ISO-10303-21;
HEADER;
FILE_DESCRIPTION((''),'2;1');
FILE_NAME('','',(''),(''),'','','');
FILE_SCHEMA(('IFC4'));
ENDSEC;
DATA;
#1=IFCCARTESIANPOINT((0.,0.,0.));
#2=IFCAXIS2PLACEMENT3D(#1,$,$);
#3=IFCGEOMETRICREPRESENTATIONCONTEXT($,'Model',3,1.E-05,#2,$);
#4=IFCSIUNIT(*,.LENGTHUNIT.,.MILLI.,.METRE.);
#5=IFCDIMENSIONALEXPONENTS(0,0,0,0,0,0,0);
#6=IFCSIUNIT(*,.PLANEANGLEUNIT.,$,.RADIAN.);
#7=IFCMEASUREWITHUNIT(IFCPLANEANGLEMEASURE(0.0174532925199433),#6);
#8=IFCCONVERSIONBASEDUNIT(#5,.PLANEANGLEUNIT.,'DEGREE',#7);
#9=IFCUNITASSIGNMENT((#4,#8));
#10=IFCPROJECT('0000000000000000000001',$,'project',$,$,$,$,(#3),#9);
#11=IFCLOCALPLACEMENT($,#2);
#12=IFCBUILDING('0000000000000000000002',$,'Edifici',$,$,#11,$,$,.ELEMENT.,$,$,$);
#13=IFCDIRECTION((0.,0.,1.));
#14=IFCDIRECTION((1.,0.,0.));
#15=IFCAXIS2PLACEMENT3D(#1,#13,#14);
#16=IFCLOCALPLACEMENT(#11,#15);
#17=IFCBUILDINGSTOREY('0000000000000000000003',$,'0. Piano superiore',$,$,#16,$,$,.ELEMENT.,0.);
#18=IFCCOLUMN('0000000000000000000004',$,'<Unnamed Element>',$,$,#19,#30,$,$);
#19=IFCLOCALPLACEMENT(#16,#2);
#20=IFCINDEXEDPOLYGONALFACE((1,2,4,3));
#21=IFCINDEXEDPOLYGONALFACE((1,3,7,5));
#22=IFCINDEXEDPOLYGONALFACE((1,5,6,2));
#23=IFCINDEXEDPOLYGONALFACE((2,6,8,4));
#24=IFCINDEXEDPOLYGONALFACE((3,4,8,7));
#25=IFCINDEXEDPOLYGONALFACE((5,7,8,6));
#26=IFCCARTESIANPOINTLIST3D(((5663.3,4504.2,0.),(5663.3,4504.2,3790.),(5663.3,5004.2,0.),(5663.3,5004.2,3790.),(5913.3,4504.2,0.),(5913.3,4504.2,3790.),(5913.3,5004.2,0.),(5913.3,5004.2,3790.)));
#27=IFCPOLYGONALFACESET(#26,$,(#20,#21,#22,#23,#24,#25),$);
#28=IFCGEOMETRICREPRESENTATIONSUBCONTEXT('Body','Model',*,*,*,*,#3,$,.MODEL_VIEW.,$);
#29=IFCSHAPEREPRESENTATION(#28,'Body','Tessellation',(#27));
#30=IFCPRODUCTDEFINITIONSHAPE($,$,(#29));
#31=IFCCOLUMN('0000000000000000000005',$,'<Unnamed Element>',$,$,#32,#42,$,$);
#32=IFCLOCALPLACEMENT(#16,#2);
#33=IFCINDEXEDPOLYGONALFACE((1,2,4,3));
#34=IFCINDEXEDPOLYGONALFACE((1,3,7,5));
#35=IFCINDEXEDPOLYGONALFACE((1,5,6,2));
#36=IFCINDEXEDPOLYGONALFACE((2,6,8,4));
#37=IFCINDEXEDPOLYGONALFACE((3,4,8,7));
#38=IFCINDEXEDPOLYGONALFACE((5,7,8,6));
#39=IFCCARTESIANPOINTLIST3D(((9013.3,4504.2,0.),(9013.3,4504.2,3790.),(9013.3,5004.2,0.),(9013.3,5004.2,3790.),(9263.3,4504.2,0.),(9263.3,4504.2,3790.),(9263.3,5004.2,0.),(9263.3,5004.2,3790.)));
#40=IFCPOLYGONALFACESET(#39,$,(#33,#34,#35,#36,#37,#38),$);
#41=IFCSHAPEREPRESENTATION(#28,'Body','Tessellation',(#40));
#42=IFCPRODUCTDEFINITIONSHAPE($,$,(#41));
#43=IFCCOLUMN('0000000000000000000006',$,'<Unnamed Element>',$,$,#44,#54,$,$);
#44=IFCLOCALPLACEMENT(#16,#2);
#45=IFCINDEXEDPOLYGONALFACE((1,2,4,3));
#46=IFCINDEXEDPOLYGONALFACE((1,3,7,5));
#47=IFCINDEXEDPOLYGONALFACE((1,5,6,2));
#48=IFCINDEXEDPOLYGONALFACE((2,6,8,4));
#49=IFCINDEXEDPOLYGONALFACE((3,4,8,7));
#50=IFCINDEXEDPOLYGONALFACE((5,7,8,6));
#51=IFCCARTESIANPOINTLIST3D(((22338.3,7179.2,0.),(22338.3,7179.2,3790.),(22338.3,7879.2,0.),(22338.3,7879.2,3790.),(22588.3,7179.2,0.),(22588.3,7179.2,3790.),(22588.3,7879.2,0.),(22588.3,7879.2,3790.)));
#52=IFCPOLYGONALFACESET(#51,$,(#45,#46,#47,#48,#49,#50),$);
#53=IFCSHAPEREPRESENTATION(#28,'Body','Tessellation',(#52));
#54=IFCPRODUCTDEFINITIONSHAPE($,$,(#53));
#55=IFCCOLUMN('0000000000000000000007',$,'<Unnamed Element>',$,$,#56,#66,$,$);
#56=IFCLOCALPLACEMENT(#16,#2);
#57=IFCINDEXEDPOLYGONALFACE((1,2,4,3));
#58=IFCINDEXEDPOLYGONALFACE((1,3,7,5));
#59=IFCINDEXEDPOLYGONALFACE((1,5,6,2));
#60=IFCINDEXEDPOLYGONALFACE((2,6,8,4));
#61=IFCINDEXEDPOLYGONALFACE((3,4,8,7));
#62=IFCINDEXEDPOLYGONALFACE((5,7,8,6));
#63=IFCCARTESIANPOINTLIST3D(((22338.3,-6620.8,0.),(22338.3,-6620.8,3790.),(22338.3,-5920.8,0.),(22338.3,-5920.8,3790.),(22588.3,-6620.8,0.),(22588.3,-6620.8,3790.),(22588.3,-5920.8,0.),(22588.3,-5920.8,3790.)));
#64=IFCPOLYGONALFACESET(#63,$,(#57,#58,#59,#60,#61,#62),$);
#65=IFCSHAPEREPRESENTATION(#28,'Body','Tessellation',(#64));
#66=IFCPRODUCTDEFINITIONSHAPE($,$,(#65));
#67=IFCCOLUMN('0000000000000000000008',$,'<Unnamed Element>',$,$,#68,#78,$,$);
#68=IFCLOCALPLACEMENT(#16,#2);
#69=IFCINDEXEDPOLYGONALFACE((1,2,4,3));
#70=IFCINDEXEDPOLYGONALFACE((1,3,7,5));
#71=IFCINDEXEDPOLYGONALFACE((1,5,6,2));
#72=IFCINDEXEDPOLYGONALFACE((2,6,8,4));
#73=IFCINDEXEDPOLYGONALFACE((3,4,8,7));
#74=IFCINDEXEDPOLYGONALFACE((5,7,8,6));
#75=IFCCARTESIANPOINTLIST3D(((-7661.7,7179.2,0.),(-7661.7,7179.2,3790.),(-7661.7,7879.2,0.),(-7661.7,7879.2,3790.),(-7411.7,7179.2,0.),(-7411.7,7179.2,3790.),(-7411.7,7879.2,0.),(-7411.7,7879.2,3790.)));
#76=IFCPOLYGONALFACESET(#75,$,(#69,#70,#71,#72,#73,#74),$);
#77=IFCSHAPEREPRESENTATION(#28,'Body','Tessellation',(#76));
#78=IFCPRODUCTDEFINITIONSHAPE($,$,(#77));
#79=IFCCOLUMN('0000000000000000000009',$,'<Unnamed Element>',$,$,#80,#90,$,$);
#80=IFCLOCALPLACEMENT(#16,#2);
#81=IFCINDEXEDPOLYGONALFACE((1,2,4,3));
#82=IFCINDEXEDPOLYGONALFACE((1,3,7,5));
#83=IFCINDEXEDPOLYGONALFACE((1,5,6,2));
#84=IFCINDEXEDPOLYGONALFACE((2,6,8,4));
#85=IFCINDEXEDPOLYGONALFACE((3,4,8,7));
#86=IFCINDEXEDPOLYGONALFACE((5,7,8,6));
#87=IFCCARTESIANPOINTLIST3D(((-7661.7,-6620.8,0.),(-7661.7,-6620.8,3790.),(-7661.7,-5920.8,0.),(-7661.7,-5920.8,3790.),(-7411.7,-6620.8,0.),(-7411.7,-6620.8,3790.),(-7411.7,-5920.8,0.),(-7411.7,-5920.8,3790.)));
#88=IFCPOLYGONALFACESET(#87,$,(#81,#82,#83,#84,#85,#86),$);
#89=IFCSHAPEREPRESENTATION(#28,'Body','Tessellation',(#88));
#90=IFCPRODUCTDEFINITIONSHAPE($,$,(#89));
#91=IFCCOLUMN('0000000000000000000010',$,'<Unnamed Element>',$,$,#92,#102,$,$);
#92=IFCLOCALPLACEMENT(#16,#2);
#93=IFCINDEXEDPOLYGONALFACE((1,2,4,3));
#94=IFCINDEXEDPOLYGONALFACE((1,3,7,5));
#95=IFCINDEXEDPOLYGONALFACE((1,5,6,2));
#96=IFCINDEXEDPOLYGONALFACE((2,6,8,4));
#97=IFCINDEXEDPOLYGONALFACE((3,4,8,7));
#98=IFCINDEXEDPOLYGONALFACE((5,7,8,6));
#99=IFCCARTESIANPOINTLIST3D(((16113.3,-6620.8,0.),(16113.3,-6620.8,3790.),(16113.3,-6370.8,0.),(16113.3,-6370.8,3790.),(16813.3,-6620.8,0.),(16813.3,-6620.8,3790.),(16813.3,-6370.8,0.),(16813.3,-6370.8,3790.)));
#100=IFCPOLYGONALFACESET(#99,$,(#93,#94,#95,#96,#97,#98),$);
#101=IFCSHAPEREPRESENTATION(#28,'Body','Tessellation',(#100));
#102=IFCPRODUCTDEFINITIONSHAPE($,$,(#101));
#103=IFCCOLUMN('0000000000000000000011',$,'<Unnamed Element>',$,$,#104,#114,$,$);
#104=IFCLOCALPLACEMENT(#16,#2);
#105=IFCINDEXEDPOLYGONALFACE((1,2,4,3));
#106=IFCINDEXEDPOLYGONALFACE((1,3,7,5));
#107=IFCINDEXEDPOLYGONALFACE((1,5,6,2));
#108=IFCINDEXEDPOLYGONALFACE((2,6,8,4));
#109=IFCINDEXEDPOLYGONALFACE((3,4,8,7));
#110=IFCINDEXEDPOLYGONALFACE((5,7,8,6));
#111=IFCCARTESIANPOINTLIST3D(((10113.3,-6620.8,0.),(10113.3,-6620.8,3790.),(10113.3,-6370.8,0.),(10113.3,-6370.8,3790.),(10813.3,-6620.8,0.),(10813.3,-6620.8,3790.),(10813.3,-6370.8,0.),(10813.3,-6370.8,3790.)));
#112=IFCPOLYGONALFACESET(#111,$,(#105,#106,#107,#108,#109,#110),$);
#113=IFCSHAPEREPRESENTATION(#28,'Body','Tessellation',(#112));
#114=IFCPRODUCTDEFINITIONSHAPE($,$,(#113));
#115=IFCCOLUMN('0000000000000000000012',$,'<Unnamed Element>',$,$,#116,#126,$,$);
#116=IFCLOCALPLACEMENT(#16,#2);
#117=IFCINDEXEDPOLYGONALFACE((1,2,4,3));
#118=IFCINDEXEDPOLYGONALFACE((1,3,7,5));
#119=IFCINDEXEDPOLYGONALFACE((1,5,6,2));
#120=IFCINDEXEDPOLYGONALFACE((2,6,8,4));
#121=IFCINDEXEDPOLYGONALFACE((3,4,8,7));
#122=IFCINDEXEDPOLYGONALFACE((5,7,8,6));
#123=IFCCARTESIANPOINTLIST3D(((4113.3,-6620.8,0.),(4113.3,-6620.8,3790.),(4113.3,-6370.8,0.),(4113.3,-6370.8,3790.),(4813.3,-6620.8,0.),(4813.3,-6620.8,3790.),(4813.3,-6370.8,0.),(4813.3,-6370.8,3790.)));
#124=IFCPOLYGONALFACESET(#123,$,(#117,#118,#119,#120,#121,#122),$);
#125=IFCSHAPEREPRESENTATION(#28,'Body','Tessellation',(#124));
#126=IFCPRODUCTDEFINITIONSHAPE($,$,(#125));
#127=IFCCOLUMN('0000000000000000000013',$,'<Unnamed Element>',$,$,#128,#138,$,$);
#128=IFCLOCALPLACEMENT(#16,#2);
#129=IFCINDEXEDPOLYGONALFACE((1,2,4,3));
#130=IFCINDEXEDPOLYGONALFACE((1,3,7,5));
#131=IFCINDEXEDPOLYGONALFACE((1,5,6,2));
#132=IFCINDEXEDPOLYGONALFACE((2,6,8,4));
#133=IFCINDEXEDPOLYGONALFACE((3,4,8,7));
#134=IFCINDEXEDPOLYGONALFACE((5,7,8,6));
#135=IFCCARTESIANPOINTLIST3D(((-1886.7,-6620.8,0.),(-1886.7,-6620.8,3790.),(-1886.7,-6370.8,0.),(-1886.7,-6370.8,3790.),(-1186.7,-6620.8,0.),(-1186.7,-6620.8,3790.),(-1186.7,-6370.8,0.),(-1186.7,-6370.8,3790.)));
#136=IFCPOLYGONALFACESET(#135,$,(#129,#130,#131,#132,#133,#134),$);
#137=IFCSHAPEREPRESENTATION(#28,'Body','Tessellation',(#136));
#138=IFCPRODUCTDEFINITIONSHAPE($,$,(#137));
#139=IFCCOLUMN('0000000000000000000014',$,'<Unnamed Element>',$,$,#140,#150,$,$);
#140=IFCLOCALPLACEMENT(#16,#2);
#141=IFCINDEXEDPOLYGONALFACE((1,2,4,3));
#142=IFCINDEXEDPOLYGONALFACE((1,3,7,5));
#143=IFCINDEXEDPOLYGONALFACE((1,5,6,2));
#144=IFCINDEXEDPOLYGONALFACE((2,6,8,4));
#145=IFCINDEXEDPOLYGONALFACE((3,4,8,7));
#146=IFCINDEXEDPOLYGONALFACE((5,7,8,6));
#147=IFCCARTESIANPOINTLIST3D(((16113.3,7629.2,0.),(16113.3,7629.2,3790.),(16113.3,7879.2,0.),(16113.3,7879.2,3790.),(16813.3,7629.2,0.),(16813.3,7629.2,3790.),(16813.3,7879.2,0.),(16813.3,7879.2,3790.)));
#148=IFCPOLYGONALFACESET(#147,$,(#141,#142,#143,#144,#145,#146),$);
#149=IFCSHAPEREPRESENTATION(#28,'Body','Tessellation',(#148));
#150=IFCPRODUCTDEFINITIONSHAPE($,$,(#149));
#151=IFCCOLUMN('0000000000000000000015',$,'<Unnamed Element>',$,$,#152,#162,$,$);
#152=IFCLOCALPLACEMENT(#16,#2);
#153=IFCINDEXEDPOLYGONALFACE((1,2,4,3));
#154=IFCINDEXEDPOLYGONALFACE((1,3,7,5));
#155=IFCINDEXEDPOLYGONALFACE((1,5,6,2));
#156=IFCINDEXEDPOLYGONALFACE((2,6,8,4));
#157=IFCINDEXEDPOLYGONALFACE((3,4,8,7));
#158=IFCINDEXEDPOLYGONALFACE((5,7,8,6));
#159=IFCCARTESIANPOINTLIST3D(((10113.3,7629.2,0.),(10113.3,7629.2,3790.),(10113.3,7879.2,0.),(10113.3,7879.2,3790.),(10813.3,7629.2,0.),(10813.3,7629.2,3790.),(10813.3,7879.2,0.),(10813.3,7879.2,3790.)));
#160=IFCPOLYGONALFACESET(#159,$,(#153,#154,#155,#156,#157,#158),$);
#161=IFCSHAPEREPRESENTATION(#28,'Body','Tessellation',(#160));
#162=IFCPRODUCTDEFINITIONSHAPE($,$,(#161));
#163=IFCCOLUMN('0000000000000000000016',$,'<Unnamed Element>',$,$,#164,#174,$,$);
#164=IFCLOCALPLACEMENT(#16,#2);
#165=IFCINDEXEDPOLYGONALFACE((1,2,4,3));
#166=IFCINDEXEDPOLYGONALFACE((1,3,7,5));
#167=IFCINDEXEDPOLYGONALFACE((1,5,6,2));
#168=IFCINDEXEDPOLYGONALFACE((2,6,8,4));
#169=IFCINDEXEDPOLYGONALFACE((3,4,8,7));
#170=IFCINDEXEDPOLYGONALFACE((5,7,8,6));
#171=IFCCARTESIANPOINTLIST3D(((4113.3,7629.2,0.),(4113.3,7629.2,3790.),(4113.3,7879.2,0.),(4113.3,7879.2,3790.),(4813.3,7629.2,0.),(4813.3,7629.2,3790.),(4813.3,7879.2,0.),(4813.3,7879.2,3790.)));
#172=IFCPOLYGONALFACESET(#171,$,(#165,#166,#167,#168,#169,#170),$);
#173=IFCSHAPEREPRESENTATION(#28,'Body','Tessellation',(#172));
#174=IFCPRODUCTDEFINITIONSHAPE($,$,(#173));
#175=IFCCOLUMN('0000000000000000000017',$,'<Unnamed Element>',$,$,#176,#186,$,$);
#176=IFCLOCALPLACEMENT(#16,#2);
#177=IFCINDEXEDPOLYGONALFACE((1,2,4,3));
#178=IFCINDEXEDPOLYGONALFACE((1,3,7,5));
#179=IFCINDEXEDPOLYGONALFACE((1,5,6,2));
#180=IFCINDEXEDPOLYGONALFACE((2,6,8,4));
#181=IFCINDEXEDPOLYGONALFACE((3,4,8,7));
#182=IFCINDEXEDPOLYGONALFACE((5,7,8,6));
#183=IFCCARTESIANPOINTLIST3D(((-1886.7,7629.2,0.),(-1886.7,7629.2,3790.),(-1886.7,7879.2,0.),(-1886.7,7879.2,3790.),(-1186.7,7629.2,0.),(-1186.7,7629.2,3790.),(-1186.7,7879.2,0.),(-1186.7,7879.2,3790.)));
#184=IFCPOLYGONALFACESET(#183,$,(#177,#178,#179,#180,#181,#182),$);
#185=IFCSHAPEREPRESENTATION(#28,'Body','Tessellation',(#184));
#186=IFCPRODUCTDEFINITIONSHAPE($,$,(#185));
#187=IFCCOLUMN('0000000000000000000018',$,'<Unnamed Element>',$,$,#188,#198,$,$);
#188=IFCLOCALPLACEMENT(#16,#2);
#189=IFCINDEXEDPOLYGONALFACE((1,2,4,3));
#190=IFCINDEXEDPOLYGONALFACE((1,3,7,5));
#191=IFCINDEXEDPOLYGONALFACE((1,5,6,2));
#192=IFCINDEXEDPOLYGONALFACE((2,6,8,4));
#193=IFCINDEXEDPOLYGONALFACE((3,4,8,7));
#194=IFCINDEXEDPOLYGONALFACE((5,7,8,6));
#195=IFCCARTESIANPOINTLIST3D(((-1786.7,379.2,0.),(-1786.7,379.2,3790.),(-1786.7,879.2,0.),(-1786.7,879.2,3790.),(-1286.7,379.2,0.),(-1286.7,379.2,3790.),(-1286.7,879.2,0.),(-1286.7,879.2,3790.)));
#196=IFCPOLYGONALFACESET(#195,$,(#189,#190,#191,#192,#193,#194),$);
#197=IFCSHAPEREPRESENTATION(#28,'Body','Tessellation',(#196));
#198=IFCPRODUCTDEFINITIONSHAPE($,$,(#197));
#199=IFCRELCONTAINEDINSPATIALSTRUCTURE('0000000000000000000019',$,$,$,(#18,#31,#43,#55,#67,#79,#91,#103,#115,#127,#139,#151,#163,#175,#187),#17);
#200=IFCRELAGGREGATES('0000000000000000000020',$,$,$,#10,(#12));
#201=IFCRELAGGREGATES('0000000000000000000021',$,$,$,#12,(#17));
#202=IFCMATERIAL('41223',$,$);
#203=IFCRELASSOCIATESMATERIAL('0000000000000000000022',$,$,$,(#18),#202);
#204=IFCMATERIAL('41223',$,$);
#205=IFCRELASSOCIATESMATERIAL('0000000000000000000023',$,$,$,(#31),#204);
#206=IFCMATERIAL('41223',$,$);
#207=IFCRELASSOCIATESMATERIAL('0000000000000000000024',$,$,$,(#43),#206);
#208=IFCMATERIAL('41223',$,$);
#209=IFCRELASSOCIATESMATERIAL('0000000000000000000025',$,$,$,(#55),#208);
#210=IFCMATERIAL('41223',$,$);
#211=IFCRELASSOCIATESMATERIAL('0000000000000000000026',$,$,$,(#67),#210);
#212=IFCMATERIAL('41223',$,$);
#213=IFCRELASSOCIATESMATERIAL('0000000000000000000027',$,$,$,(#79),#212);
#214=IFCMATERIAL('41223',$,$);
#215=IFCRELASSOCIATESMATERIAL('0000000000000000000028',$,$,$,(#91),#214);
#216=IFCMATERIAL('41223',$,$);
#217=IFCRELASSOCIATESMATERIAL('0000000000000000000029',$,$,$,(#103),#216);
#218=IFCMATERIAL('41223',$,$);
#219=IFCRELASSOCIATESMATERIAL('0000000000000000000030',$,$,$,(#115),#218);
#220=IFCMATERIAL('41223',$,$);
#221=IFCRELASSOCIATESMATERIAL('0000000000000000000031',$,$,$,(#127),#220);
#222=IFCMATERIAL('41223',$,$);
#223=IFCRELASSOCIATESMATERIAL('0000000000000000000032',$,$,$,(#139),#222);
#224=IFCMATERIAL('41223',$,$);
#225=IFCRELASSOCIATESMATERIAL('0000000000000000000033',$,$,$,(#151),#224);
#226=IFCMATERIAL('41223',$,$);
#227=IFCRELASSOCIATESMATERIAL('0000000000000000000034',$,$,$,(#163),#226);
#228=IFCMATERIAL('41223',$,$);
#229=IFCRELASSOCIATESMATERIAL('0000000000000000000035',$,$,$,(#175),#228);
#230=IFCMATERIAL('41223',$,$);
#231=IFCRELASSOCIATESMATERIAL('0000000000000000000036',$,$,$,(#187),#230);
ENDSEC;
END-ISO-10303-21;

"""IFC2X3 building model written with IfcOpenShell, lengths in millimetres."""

from ifc_helpers import new_model, entity, si_unit, converted_unit, frame, frame_2d, origin, origin_with_axes, place, context, subcontext, project, spatial, rectangle, extrude, material, element, save


model = new_model("IFC2X3")

# Units and contexts
model_context = context("Model", 3, precision=1e-05, world=origin())
body_context = subcontext(model_context, "Body", "Model", "MODEL_VIEW")
ifc_project = project(units=[si_unit("LENGTHUNIT", "METRE", prefix="MILLI"), converted_unit("PLANEANGLEUNIT", "DEGREE", entity("IfcPlaneAngleMeasure", 0.0174532925199433), si_unit("PLANEANGLEUNIT", "RADIAN"), dimensions=[0, 0, 0, 0, 0, 0, 0])], contexts=[model_context])

# Building, storey
building_placement = place(None, origin())
building = spatial("IfcBuilding", under=ifc_project, at=building_placement, Name="Edifici", CompositionType="ELEMENT")
storey_placement = place(building_placement, origin_with_axes())
storey = spatial("IfcBuildingStorey", under=building, at=storey_placement, Name="0. Piano superiore", CompositionType="ELEMENT", Elevation=0.0)

# Columns
ifc_material_1 = material(Name="41223")
column_1_placement = place(storey_placement, frame((5913.3, 5004.2, 0.0), z_axis=(0.0, 0.0, 1.0), x_axis=(1.0, 0.0, 0.0)))
element("IfcColumn", 1, at=column_1_placement, inside=storey, material=ifc_material_1, Name="<Unnamed Element>", context=body_context, shape_type="SweptSolid", body=[
    extrude(rectangle(XDim=250.0, YDim=500.0, at=frame_2d((-125.0, -250.0), x_axis=(-1.0, 0.0))), origin_with_axes(), (0.0, 0.0, 1.0), 3790.0),
])
ifc_material_2 = material(Name="41223")
column_2_placement = place(storey_placement, frame((9263.3, 5004.2, 0.0), z_axis=(0.0, 0.0, 1.0), x_axis=(1.0, 0.0, 0.0)))
element("IfcColumn", 2, at=column_2_placement, inside=storey, material=ifc_material_2, Name="<Unnamed Element>", context=body_context, shape_type="SweptSolid", body=[
    extrude(rectangle(XDim=250.0, YDim=500.0, at=frame_2d((-125.0, -250.0), x_axis=(-1.0, 0.0))), origin_with_axes(), (0.0, 0.0, 1.0), 3790.0),
])
ifc_material_3 = material(Name="41223")
column_3_placement = place(storey_placement, frame((22588.3, 7879.2, 0.0), z_axis=(0.0, 0.0, 1.0), x_axis=(1.0, 0.0, 0.0)))
element("IfcColumn", 3, at=column_3_placement, inside=storey, material=ifc_material_3, Name="<Unnamed Element>", context=body_context, shape_type="SweptSolid", body=[
    extrude(rectangle(XDim=250.0, YDim=700.0, at=frame_2d((-125.0, -350.0), x_axis=(-1.0, 0.0))), origin_with_axes(), (0.0, 0.0, 1.0), 3790.0),
])
ifc_material_4 = material(Name="41223")
column_4_placement = place(storey_placement, frame((22588.3, -5920.8, 0.0), z_axis=(0.0, 0.0, 1.0), x_axis=(1.0, 0.0, 0.0)))
element("IfcColumn", 4, at=column_4_placement, inside=storey, material=ifc_material_4, Name="<Unnamed Element>", context=body_context, shape_type="SweptSolid", body=[
    extrude(rectangle(XDim=250.0, YDim=700.0, at=frame_2d((-125.0, -350.0), x_axis=(-1.0, 0.0))), origin_with_axes(), (0.0, 0.0, 1.0), 3790.0),
])
ifc_material_5 = material(Name="41223")
column_5_placement = place(storey_placement, frame((-7411.7, 7879.2, 0.0), z_axis=(0.0, 0.0, 1.0), x_axis=(1.0, 0.0, 0.0)))
element("IfcColumn", 5, at=column_5_placement, inside=storey, material=ifc_material_5, Name="<Unnamed Element>", context=body_context, shape_type="SweptSolid", body=[
    extrude(rectangle(XDim=250.0, YDim=700.0, at=frame_2d((-125.0, -350.0), x_axis=(-1.0, 0.0))), origin_with_axes(), (0.0, 0.0, 1.0), 3790.0),
])
ifc_material_6 = material(Name="41223")
column_6_placement = place(storey_placement, frame((-7411.7, -5920.8, 0.0), z_axis=(0.0, 0.0, 1.0), x_axis=(1.0, 0.0, 0.0)))
element("IfcColumn", 6, at=column_6_placement, inside=storey, material=ifc_material_6, Name="<Unnamed Element>", context=body_context, shape_type="SweptSolid", body=[
    extrude(rectangle(XDim=250.0, YDim=700.0, at=frame_2d((-125.0, -350.0), x_axis=(-1.0, 0.0))), origin_with_axes(), (0.0, 0.0, 1.0), 3790.0),
])
ifc_material_7 = material(Name="41223")
column_7_placement = place(storey_placement, frame((16813.3, -6620.8, 0.0), z_axis=(0.0, 0.0, 1.0), x_axis=(1.0, 0.0, 0.0)))
element("IfcColumn", 7, at=column_7_placement, inside=storey, material=ifc_material_7, Name="<Unnamed Element>", context=body_context, shape_type="SweptSolid", body=[
    extrude(rectangle(XDim=250.0, YDim=700.0, at=frame_2d((-350.0, 125.0), x_axis=(0.0, 1.0))), origin_with_axes(), (0.0, 0.0, 1.0), 3790.0),
])
ifc_material_8 = material(Name="41223")
column_8_placement = place(storey_placement, frame((10813.3, -6620.8, 0.0), z_axis=(0.0, 0.0, 1.0), x_axis=(1.0, 0.0, 0.0)))
element("IfcColumn", 8, at=column_8_placement, inside=storey, material=ifc_material_8, Name="<Unnamed Element>", context=body_context, shape_type="SweptSolid", body=[
    extrude(rectangle(XDim=250.0, YDim=700.0, at=frame_2d((-350.0, 125.0), x_axis=(0.0, 1.0))), origin_with_axes(), (0.0, 0.0, 1.0), 3790.0),
])
ifc_material_9 = material(Name="41223")
column_9_placement = place(storey_placement, frame((4813.3, -6620.8, 0.0), z_axis=(0.0, 0.0, 1.0), x_axis=(1.0, 0.0, 0.0)))
element("IfcColumn", 9, at=column_9_placement, inside=storey, material=ifc_material_9, Name="<Unnamed Element>", context=body_context, shape_type="SweptSolid", body=[
    extrude(rectangle(XDim=250.0, YDim=700.0, at=frame_2d((-350.0, 125.0), x_axis=(0.0, 1.0))), origin_with_axes(), (0.0, 0.0, 1.0), 3790.0),
])
ifc_material_10 = material(Name="41223")
column_10_placement = place(storey_placement, frame((-1186.7, -6620.8, 0.0), z_axis=(0.0, 0.0, 1.0), x_axis=(1.0, 0.0, 0.0)))
element("IfcColumn", 10, at=column_10_placement, inside=storey, material=ifc_material_10, Name="<Unnamed Element>", context=body_context, shape_type="SweptSolid", body=[
    extrude(rectangle(XDim=250.0, YDim=700.0, at=frame_2d((-350.0, 125.0), x_axis=(0.0, 1.0))), origin_with_axes(), (0.0, 0.0, 1.0), 3790.0),
])
ifc_material_11 = material(Name="41223")
column_11_placement = place(storey_placement, frame((16813.3, 7629.2, 0.0), z_axis=(0.0, 0.0, 1.0), x_axis=(1.0, 0.0, 0.0)))
element("IfcColumn", 11, at=column_11_placement, inside=storey, material=ifc_material_11, Name="<Unnamed Element>", context=body_context, shape_type="SweptSolid", body=[
    extrude(rectangle(XDim=250.0, YDim=700.0, at=frame_2d((-350.0, 125.0), x_axis=(0.0, 1.0))), origin_with_axes(), (0.0, 0.0, 1.0), 3790.0),
])
ifc_material_12 = material(Name="41223")
column_12_placement = place(storey_placement, frame((10813.3, 7629.2, 0.0), z_axis=(0.0, 0.0, 1.0), x_axis=(1.0, 0.0, 0.0)))
element("IfcColumn", 12, at=column_12_placement, inside=storey, material=ifc_material_12, Name="<Unnamed Element>", context=body_context, shape_type="SweptSolid", body=[
    extrude(rectangle(XDim=250.0, YDim=700.0, at=frame_2d((-350.0, 125.0), x_axis=(0.0, 1.0))), origin_with_axes(), (0.0, 0.0, 1.0), 3790.0),
])
ifc_material_13 = material(Name="41223")
column_13_placement = place(storey_placement, frame((4813.3, 7629.2, 0.0), z_axis=(0.0, 0.0, 1.0), x_axis=(1.0, 0.0, 0.0)))
element("IfcColumn", 13, at=column_13_placement, inside=storey, material=ifc_material_13, Name="<Unnamed Element>", context=body_context, shape_type="SweptSolid", body=[
    extrude(rectangle(XDim=250.0, YDim=700.0, at=frame_2d((-350.0, 125.0), x_axis=(0.0, 1.0))), origin_with_axes(), (0.0, 0.0, 1.0), 3790.0),
])
ifc_material_14 = material(Name="41223")
column_14_placement = place(storey_placement, frame((-1186.7, 7629.2, 0.0), z_axis=(0.0, 0.0, 1.0), x_axis=(1.0, 0.0, 0.0)))
element("IfcColumn", 14, at=column_14_placement, inside=storey, material=ifc_material_14, Name="<Unnamed Element>", context=body_context, shape_type="SweptSolid", body=[
    extrude(rectangle(XDim=250.0, YDim=700.0, at=frame_2d((-350.0, 125.0), x_axis=(0.0, 1.0))), origin_with_axes(), (0.0, 0.0, 1.0), 3790.0),
])
ifc_material_15 = material(Name="41223")
column_15_placement = place(storey_placement, frame((-1786.7, 379.2, 0.0), z_axis=(0.0, 0.0, 1.0), x_axis=(1.0, 0.0, 0.0)))
element("IfcColumn", 15, at=column_15_placement, inside=storey, material=ifc_material_15, Name="<Unnamed Element>", context=body_context, shape_type="SweptSolid", body=[
    extrude(rectangle(XDim=500.0, YDim=500.0, at=frame_2d((250.0, 250.0), x_axis=(1.0, 0.0))), origin_with_axes(), (0.0, 0.0, 1.0), 3790.0),
])

save(model, "model.ifc")
